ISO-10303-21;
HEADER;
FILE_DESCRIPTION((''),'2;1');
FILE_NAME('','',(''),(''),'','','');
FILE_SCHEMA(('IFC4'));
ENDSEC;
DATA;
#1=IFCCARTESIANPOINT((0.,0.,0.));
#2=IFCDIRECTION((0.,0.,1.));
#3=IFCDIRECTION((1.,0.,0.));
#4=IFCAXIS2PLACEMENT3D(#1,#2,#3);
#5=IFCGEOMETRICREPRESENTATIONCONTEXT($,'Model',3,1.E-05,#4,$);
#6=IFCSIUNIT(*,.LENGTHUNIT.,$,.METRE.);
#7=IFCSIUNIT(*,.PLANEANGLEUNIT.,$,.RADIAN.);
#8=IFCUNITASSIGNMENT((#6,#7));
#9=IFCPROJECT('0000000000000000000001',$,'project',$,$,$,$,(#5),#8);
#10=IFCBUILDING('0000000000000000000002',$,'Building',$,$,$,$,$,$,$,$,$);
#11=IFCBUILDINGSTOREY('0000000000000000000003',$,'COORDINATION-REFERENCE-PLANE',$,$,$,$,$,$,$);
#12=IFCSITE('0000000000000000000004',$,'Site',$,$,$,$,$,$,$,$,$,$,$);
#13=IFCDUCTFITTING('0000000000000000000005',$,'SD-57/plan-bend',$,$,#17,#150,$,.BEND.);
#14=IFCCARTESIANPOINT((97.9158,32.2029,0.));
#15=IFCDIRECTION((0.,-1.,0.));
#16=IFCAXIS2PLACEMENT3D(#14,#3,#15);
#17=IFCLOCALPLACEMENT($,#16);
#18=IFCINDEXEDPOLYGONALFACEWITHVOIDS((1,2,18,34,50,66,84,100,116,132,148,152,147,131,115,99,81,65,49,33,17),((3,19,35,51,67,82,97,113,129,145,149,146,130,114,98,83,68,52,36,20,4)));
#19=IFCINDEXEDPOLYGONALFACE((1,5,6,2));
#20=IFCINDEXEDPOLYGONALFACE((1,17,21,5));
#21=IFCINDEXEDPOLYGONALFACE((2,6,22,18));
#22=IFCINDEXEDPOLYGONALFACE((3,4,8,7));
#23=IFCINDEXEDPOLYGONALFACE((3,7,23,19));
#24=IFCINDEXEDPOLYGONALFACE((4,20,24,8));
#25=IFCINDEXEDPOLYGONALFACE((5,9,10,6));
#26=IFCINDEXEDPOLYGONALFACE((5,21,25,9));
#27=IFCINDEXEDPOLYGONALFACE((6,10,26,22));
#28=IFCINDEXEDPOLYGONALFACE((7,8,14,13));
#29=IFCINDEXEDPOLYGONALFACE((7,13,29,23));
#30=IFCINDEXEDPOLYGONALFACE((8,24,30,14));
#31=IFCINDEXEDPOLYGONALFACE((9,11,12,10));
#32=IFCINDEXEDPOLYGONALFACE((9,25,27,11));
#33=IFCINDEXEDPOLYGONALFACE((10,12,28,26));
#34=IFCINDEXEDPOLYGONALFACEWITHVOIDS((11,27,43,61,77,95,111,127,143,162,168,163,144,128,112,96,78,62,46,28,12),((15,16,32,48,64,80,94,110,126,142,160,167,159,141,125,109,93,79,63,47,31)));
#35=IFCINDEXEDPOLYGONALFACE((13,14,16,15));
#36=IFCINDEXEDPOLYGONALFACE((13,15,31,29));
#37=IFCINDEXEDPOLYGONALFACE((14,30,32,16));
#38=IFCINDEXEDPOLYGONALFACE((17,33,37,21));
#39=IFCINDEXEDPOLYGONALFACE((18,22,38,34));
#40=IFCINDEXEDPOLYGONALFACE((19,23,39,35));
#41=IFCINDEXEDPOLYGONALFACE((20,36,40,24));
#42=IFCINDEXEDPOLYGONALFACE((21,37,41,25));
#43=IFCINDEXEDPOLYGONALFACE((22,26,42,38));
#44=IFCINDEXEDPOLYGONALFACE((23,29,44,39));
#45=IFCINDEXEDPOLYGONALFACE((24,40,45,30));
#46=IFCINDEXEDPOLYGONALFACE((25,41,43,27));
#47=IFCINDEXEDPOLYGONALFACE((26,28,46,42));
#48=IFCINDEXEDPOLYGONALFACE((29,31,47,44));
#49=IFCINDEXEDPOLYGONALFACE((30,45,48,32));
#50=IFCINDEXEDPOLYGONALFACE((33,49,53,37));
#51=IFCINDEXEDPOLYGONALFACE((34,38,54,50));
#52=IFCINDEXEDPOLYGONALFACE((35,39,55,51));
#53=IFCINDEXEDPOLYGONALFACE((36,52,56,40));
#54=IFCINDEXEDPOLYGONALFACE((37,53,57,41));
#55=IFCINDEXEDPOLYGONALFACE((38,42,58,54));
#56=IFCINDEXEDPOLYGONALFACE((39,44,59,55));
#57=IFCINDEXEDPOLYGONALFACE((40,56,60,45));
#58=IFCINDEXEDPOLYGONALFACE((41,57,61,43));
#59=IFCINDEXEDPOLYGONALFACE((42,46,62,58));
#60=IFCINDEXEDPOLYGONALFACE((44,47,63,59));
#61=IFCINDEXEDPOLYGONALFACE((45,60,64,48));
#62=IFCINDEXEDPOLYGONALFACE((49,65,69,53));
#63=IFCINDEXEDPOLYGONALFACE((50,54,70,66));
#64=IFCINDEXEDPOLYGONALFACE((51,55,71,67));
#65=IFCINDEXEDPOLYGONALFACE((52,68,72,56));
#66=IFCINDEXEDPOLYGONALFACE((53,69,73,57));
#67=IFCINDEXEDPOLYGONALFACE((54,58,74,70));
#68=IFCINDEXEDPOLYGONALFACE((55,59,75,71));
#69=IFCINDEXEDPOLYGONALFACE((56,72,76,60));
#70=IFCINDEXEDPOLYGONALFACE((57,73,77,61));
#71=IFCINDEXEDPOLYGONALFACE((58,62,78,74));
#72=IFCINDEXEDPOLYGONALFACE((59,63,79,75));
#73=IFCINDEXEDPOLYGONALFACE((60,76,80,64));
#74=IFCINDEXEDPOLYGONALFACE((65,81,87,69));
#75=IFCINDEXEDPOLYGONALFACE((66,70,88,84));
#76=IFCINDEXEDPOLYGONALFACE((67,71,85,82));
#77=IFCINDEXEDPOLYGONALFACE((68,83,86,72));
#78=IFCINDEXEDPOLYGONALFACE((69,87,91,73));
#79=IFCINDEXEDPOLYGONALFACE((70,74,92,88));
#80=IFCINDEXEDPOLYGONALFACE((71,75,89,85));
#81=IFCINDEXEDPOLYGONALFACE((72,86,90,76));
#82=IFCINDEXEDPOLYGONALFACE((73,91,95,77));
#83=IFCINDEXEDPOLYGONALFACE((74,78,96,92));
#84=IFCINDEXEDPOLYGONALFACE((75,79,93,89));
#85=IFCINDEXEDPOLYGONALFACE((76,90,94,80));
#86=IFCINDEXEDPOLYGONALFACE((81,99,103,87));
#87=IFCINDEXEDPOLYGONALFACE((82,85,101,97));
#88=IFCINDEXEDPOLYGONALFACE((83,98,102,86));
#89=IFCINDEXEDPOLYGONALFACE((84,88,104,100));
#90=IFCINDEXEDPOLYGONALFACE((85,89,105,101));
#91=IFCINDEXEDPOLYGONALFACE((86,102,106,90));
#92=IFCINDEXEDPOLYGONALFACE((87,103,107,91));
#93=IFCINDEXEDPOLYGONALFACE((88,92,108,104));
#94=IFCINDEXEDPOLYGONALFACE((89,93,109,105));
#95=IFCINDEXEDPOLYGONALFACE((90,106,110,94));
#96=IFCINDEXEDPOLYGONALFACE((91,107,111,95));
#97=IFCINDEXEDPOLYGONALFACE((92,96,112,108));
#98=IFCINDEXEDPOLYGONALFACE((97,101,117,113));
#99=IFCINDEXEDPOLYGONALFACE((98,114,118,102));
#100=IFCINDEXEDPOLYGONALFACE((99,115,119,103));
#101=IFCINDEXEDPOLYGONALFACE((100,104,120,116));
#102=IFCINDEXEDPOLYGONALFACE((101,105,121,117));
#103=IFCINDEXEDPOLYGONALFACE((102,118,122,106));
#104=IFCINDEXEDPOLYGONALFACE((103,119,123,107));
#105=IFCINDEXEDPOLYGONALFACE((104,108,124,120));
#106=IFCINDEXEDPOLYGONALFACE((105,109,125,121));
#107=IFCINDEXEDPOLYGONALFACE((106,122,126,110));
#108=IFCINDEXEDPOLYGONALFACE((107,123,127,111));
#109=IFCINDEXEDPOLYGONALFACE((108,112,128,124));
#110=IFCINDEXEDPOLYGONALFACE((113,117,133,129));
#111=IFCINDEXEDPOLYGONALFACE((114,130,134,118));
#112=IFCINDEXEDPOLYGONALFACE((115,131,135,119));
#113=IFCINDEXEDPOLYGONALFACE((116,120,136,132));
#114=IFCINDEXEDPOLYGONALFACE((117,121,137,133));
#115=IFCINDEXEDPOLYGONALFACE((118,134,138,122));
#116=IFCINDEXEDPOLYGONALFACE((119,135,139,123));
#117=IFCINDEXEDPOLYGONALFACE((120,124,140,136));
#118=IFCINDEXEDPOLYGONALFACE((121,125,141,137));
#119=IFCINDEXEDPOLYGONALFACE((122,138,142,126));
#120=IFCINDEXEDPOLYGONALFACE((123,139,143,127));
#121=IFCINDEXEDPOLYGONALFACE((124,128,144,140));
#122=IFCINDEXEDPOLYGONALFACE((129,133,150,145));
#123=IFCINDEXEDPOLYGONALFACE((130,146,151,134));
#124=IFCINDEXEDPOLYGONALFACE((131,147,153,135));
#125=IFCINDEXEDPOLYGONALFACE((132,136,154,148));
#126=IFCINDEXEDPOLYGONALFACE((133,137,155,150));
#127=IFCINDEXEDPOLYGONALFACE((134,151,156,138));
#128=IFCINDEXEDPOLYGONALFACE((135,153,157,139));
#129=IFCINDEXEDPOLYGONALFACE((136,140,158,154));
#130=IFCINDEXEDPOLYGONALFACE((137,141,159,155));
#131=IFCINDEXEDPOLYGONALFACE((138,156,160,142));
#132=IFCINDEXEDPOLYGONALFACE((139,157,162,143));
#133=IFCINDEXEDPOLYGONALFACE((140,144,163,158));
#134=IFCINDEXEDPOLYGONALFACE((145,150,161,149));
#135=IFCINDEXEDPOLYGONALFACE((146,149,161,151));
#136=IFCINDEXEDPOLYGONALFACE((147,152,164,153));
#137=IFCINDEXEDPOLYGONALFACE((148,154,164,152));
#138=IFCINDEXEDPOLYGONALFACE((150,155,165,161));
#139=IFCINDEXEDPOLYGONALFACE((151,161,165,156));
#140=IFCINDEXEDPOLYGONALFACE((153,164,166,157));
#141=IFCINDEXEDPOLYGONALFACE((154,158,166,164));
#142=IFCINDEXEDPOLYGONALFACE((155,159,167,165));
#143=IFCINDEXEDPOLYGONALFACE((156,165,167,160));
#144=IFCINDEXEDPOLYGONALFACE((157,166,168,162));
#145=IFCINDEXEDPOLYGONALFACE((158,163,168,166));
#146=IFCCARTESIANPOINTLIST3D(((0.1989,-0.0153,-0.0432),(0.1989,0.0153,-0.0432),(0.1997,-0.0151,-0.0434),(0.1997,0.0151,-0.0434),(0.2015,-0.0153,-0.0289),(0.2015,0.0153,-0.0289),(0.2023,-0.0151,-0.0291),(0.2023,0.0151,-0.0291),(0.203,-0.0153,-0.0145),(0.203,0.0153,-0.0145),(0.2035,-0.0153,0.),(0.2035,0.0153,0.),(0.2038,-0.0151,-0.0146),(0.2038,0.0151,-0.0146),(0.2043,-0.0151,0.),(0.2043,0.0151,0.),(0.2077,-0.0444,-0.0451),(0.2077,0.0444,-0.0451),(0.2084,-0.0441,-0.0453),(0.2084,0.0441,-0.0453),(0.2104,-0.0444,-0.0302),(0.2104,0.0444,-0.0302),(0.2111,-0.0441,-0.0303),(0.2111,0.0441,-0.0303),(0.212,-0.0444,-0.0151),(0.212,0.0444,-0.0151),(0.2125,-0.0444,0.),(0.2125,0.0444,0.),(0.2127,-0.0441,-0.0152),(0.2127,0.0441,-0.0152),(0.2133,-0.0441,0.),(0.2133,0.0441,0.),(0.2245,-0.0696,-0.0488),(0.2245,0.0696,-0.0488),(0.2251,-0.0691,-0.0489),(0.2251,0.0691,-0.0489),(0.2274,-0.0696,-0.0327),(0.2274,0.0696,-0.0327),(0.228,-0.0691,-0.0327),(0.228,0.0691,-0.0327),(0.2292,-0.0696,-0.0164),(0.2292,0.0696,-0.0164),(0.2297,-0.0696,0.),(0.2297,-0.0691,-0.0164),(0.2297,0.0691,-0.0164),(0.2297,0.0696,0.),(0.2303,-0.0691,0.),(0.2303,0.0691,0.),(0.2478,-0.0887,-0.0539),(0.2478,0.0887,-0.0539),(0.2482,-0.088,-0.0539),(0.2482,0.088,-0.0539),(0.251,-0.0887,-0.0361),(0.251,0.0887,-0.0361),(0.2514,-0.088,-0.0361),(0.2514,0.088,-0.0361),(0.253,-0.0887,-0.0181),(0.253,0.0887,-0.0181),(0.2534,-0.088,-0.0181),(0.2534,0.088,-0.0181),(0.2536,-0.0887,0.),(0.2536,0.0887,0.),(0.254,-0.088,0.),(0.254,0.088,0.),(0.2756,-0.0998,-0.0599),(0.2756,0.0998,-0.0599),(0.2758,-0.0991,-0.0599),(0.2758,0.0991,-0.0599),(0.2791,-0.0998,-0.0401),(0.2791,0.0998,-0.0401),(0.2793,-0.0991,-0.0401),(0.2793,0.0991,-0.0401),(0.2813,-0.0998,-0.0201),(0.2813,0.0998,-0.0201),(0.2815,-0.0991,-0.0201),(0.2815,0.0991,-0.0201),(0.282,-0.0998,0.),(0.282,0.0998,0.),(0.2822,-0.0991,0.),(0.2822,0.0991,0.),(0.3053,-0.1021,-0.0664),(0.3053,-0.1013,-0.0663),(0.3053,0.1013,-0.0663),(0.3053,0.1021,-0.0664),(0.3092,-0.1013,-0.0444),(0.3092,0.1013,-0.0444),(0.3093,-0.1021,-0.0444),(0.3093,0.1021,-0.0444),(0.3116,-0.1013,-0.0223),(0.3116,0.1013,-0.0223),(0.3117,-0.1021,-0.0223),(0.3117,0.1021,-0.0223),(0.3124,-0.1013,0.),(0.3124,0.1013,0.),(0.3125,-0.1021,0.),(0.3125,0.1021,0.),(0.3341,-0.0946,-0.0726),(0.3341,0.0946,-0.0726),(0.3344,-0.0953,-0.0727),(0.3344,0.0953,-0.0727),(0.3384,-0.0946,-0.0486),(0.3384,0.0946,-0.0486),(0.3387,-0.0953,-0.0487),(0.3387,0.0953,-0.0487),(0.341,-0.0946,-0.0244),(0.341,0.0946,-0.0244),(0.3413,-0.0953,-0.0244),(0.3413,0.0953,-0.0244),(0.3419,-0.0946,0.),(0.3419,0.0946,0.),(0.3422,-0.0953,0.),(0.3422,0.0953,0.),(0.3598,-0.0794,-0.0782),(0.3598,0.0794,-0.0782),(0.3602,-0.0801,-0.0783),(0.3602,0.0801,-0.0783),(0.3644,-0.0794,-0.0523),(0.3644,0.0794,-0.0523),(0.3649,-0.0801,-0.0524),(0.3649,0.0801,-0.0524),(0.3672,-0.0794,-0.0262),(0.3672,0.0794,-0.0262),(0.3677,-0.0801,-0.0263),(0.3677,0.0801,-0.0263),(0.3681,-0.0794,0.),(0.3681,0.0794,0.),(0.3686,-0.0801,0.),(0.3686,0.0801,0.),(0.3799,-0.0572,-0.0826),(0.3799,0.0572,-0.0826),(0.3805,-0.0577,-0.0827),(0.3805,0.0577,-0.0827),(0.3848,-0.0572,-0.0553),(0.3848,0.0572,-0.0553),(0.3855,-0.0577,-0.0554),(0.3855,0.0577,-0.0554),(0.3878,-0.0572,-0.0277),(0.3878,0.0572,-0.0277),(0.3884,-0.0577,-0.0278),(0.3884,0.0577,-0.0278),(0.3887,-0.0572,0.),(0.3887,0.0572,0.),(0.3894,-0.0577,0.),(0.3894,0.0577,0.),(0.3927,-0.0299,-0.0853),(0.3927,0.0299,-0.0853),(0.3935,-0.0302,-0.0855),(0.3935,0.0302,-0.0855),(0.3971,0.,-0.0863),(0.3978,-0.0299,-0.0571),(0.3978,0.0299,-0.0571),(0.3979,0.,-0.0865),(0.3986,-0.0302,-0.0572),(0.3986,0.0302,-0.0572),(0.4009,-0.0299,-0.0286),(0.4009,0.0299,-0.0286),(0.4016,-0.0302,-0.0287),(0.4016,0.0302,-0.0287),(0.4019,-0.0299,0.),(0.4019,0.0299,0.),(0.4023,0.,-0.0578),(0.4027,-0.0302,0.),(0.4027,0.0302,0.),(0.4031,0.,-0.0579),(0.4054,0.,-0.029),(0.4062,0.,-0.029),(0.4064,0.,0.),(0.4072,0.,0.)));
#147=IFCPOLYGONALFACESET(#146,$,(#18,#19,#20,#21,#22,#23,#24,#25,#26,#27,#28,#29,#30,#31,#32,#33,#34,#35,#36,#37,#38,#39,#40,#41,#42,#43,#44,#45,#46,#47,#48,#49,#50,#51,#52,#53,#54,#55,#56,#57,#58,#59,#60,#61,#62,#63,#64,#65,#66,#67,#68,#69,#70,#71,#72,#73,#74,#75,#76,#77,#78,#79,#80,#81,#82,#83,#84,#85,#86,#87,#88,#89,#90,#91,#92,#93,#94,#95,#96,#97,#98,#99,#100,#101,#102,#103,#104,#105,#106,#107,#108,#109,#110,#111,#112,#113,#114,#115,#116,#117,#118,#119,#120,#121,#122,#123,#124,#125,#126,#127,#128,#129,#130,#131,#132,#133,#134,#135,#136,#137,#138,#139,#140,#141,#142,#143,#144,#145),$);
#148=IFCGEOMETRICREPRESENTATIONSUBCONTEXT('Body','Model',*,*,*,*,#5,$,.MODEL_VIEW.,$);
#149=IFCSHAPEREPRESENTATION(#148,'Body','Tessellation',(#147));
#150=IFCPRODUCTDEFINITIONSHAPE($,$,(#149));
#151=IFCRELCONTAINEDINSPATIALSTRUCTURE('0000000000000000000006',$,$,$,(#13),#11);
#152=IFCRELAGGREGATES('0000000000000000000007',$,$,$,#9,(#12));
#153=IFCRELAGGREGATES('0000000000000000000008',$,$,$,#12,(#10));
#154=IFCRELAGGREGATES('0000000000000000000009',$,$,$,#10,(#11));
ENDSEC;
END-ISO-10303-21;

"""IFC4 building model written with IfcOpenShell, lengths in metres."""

from ifc_helpers import new_model, entity, si_unit, frame, origin_with_axes, place, context, subcontext, project, spatial, element, save


model = new_model("IFC4")

# Units and contexts
model_context = context("Model", 3, precision=1e-05, world=origin_with_axes())
body_context_1 = subcontext(model_context, "Body", "Model", "MODEL_VIEW")
ifc_project = project(units=[si_unit("LENGTHUNIT", "METRE"), si_unit("PLANEANGLEUNIT", "RADIAN")], contexts=[model_context])

# Site, building, storey
site = spatial("IfcSite", under=ifc_project, Name="Site")
building = spatial("IfcBuilding", under=site, Name="Building")
storey = spatial("IfcBuildingStorey", under=building, Name="COORDINATION-REFERENCE-PLANE")

# Duct fitting
duct_fitting_1_placement = place(None, frame((97.9158, 32.2029, 0.0), z_axis=(1.0, 0.0, 0.0), x_axis=(0.0, -1.0, 0.0)))
element("IfcDuctFitting", 1, at=duct_fitting_1_placement, inside=storey, Name="SD-57/plan-bend", PredefinedType="BEND", context=body_context_1, shape_type="SweptSolid", body=[
    entity("IfcRevolvedAreaSolid", entity("IfcCircleHollowProfileDef", "AREA", None, entity("IfcAxis2Placement2D", entity("IfcCartesianPoint", [0.3048, 0.0])), 0.1024, 0.0008), entity("IfcAxis2Placement3D", entity("IfcCartesianPoint", [0.0, 0.0, 0.0]), entity("IfcDirection", [0.0, 0.0, 1.0]), entity("IfcDirection", [1.0, 0.0, 0.0])), entity("IfcAxis1Placement", entity("IfcCartesianPoint", [0.0, 0.0, 0.0]), entity("IfcDirection", [0.0, 1.0, 0.0])), 0.213982),
])

save(model, "model.ifc")
